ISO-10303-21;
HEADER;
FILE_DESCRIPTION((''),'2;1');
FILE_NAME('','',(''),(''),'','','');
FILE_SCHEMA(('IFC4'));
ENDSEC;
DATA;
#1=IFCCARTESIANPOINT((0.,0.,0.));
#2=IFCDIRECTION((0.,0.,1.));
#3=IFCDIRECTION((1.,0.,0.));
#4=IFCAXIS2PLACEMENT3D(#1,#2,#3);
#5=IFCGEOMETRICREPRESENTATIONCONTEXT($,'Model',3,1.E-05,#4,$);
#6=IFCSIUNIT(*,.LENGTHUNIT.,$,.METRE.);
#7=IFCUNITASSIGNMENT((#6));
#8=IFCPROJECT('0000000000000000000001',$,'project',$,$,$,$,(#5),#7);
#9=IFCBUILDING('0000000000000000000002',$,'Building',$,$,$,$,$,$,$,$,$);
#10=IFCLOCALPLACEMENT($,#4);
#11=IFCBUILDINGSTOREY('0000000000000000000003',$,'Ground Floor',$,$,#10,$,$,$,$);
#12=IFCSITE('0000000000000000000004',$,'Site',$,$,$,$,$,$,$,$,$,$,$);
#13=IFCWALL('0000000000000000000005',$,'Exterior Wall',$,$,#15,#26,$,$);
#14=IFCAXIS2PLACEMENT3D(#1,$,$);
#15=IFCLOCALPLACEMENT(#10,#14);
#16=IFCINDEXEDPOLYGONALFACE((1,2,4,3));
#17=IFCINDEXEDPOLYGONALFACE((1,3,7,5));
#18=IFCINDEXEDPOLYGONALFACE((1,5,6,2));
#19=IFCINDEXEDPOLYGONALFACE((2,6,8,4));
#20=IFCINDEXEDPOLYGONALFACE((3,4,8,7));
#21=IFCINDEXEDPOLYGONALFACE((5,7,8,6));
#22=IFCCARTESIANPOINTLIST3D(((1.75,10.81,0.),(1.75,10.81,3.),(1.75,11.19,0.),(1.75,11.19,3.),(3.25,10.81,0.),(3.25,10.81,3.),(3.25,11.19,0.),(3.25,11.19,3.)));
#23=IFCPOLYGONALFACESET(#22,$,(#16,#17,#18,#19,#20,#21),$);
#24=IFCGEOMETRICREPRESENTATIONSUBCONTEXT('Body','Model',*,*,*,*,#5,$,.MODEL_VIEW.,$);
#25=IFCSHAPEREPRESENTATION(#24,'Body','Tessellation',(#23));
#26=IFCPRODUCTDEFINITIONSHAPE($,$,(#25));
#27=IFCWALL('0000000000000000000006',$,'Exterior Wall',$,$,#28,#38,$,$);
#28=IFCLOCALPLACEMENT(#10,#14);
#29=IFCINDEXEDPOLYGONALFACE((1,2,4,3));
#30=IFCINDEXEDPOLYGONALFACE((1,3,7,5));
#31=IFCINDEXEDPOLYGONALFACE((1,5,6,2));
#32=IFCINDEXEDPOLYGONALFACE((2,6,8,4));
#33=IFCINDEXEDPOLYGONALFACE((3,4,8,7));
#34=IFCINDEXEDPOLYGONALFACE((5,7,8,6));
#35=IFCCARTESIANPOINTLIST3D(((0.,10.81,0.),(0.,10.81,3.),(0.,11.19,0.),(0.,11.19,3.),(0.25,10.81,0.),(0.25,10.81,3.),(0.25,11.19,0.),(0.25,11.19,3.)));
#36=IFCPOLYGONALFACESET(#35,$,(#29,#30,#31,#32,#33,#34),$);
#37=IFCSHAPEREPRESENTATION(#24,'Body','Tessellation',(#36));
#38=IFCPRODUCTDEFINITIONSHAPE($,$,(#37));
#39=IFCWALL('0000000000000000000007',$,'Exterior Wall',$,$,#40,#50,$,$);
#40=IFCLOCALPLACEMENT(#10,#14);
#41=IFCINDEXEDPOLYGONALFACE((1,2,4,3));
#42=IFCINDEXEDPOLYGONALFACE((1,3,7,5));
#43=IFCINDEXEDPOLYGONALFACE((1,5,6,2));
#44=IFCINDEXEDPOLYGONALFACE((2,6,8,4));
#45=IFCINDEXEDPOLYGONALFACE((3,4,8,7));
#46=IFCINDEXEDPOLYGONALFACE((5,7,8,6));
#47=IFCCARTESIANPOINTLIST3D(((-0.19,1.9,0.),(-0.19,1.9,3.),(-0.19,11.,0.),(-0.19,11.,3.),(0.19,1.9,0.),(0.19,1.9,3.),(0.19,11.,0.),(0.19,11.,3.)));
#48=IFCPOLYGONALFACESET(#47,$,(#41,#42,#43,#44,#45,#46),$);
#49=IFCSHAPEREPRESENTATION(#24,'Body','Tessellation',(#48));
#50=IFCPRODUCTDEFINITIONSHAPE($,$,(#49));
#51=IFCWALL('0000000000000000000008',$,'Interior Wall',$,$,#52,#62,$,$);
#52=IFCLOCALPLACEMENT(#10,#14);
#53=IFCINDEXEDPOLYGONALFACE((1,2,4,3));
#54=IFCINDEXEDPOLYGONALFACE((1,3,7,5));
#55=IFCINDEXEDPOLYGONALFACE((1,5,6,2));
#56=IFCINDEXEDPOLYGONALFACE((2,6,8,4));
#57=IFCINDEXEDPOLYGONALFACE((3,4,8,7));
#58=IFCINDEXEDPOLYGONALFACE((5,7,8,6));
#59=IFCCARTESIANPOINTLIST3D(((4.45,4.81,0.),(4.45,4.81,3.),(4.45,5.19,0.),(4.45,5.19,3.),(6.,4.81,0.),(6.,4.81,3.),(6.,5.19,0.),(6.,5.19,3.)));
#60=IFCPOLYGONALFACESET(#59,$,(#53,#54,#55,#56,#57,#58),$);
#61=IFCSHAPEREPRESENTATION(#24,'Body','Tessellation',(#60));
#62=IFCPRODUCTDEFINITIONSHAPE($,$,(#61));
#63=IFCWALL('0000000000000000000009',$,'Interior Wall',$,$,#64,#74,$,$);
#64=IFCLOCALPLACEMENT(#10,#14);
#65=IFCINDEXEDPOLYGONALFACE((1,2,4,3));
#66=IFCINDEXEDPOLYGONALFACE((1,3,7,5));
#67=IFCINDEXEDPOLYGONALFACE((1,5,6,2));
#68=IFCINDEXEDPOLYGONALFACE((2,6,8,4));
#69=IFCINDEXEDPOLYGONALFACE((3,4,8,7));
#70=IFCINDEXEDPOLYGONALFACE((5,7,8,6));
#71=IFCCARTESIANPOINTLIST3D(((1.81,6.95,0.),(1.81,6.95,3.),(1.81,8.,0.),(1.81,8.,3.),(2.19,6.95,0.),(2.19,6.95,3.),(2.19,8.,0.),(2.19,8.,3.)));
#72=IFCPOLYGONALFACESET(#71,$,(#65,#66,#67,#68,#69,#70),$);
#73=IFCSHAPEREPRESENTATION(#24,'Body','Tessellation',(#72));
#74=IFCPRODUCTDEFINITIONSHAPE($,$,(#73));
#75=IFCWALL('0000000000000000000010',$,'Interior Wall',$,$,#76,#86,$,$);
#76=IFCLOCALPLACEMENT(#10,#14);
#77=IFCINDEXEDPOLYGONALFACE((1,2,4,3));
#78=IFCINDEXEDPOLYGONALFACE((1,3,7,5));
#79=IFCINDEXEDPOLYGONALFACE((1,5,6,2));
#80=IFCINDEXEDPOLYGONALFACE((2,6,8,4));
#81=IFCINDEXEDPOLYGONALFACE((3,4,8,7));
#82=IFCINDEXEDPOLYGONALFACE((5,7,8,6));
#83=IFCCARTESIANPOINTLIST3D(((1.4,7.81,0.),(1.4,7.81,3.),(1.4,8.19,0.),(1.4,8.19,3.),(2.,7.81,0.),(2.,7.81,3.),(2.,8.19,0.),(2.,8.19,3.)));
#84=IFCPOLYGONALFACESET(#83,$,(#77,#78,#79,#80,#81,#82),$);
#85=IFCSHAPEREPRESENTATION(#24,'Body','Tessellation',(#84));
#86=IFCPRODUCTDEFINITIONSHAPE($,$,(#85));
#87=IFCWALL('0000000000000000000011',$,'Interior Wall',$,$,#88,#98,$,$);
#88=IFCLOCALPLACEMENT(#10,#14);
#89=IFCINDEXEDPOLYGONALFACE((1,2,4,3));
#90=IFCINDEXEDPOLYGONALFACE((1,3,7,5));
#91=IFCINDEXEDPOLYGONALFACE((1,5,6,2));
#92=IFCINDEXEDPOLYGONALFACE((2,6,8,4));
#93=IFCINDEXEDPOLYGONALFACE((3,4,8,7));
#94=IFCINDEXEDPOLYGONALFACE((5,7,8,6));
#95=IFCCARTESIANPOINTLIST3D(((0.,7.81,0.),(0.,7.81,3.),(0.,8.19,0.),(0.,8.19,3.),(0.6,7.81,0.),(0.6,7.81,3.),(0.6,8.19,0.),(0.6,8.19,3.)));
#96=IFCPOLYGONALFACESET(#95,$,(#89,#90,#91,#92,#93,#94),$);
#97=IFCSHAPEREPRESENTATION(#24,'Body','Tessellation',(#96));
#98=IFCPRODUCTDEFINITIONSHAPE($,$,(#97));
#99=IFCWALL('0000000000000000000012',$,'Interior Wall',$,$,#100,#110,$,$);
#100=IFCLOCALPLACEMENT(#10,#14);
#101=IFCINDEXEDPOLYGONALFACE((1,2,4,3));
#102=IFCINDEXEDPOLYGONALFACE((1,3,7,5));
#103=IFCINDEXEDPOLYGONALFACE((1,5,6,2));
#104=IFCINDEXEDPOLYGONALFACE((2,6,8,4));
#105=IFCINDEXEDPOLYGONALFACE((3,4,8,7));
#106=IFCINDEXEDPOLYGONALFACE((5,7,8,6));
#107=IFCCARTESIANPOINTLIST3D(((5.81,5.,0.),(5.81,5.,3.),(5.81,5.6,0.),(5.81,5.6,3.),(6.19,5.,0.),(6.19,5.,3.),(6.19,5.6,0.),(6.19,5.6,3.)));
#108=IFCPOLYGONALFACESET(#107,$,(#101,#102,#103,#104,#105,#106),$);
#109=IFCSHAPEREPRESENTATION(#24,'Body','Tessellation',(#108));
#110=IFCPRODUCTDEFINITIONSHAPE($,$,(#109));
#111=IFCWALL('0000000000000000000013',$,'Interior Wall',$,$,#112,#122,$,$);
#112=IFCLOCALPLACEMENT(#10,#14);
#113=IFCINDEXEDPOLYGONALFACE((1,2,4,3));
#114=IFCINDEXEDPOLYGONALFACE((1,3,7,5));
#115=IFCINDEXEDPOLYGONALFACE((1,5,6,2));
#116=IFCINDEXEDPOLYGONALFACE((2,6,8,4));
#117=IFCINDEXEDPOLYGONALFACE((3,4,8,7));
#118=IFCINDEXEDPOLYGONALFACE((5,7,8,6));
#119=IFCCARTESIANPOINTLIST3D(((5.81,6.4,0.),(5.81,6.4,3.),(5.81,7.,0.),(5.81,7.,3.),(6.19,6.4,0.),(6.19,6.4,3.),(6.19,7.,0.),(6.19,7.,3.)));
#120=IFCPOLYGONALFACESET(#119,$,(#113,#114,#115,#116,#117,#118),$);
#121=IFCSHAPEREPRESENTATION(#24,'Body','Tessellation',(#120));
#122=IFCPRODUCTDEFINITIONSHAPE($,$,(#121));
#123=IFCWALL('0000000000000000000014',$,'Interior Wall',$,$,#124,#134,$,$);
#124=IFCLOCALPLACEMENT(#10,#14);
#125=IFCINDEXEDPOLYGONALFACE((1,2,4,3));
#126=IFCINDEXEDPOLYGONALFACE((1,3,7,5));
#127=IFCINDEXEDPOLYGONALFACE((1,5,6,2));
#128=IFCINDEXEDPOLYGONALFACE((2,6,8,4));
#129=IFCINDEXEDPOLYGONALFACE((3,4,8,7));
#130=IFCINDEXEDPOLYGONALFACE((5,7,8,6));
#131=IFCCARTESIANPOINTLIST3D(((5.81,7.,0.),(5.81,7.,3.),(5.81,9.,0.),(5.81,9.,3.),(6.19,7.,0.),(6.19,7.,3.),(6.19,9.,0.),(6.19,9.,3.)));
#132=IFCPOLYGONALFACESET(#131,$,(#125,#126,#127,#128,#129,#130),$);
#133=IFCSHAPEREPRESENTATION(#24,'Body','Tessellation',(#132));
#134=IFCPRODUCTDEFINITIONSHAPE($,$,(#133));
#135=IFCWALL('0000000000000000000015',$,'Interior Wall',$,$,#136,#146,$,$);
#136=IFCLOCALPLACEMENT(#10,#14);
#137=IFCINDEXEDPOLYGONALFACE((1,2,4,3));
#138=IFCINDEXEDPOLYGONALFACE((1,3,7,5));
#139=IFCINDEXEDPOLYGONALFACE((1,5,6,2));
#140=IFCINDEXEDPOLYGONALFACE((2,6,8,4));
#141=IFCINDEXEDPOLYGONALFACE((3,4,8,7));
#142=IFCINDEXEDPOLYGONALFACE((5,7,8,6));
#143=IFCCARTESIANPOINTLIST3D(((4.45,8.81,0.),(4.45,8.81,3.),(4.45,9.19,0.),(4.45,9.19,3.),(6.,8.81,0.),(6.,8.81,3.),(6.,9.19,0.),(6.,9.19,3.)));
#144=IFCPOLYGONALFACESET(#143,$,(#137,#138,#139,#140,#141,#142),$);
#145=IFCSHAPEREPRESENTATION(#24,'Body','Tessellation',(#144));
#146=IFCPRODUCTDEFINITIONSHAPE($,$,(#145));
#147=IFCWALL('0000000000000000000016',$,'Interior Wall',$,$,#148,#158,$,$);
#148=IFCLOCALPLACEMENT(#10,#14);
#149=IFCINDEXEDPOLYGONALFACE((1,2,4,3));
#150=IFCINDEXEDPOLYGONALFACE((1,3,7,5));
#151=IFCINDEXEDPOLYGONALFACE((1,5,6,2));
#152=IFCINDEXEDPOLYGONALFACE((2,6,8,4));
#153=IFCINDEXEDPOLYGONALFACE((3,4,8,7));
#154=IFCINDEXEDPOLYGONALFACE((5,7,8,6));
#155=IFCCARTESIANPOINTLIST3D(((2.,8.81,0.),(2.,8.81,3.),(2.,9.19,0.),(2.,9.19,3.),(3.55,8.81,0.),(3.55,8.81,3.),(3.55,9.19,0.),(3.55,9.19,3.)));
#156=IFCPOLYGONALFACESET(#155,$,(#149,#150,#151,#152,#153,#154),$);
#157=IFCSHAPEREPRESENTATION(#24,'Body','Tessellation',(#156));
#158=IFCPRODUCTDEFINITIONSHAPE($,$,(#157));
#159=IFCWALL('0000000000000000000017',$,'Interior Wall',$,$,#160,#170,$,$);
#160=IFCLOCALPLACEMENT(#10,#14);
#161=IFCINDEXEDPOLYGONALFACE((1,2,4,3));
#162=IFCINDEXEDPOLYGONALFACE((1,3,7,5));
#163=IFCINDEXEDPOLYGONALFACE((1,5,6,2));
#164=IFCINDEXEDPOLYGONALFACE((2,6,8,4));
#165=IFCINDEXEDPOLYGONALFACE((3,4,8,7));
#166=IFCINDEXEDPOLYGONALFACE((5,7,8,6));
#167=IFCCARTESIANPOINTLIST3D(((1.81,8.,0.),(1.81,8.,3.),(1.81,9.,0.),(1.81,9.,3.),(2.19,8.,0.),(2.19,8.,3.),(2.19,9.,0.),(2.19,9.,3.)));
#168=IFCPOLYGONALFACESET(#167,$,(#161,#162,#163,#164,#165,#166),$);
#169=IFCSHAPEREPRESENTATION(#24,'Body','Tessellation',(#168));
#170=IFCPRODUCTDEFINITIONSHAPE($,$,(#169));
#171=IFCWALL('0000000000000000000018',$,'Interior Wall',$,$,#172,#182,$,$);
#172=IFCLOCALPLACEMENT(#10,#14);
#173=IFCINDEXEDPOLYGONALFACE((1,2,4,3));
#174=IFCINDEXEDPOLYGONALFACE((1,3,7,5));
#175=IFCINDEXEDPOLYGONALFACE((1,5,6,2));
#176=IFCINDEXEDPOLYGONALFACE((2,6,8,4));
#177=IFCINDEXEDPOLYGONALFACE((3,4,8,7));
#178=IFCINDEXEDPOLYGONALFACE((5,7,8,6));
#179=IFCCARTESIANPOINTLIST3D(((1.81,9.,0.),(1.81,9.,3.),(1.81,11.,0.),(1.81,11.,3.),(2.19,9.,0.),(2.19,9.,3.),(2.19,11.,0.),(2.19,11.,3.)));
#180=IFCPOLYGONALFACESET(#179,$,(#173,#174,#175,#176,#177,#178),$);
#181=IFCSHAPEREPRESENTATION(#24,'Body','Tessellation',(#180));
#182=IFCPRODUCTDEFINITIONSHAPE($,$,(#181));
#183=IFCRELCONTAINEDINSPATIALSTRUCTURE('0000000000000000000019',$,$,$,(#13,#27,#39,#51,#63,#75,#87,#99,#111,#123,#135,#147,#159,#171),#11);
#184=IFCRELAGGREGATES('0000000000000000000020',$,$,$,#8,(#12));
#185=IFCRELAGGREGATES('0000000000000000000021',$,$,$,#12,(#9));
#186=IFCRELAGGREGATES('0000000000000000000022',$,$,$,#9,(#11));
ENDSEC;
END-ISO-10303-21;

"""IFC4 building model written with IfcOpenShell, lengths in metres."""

from ifc_helpers import new_model, si_unit, frame, origin_with_axes, place, context, subcontext, project, spatial, indexed_curve, outline, extrude, element, save


model = new_model("IFC4")

# Units and contexts
model_context = context("Model", 3, precision=1e-05, world=origin_with_axes())
body_context = subcontext(model_context, "Body", "Model", "MODEL_VIEW")
ifc_project = project(units=[si_unit("LENGTHUNIT", "METRE")], contexts=[model_context])

# Site, building, storey
site = spatial("IfcSite", under=ifc_project, Name="Site")
building = spatial("IfcBuilding", under=site, Name="Building")
storey_placement = place(None, origin_with_axes())
storey = spatial("IfcBuildingStorey", under=building, at=storey_placement, Name="Ground Floor")

# Walls
wall_1_placement = place(storey_placement, frame((3.25, 11.0, 0.0), z_axis=(0.0, 0.0, 1.0), x_axis=(-1.0, 0.0, 0.0)))
element("IfcWall", 1, at=wall_1_placement, inside=storey, Name="Exterior Wall", context=body_context, shape_type="SweptSolid", body=[
    extrude(outline(indexed_curve([(0.0, 0.0), (0.0, 0.38), (1.5, 0.38), (1.5, 0.0), (0.0, 0.0)], self_intersect=False)), frame((0.0, -0.19, 0.0), z_axis=(0.0, 0.0, 1.0), x_axis=(1.0, 0.0, 0.0)), (0.0, 0.0, 1.0), 3.0),
])
wall_2_placement = place(storey_placement, frame((0.25, 11.0, 0.0), z_axis=(0.0, 0.0, 1.0), x_axis=(-1.0, 0.0, 0.0)))
element("IfcWall", 2, at=wall_2_placement, inside=storey, Name="Exterior Wall", context=body_context, shape_type="SweptSolid", body=[
    extrude(outline(indexed_curve([(0.0, 0.0), (0.0, 0.38), (0.25, 0.38), (0.25, 0.0), (0.0, 0.0)], self_intersect=False)), frame((0.0, -0.19, 0.0), z_axis=(0.0, 0.0, 1.0), x_axis=(1.0, 0.0, 0.0)), (0.0, 0.0, 1.0), 3.0),
])
wall_3_placement = place(storey_placement, frame((0.0, 11.0, 0.0), z_axis=(0.0, 0.0, 1.0), x_axis=(0.0, -1.0, 0.0)))
element("IfcWall", 3, at=wall_3_placement, inside=storey, Name="Exterior Wall", context=body_context, shape_type="SweptSolid", body=[
    extrude(outline(indexed_curve([(0.0, 0.0), (0.0, 0.38), (9.1, 0.38), (9.1, 0.0), (0.0, 0.0)], self_intersect=False)), frame((0.0, -0.19, 0.0), z_axis=(0.0, 0.0, 1.0), x_axis=(1.0, 0.0, 0.0)), (0.0, 0.0, 1.0), 3.0),
])
wall_4_placement = place(storey_placement, frame((6.0, 5.0, 0.0), z_axis=(0.0, 0.0, 1.0), x_axis=(-1.0, 0.0, 0.0)))
element("IfcWall", 4, at=wall_4_placement, inside=storey, Name="Interior Wall", context=body_context, shape_type="SweptSolid", body=[
    extrude(outline(indexed_curve([(0.0, 0.0), (0.0, 0.38), (1.55, 0.38), (1.55, 0.0), (0.0, 0.0)], self_intersect=False)), frame((0.0, -0.19, 0.0), z_axis=(0.0, 0.0, 1.0), x_axis=(1.0, 0.0, 0.0)), (0.0, 0.0, 1.0), 3.0),
])
wall_5_placement = place(storey_placement, frame((2.0, 6.95, 0.0), z_axis=(0.0, 0.0, 1.0), x_axis=(0.0, 1.0, 0.0)))
element("IfcWall", 5, at=wall_5_placement, inside=storey, Name="Interior Wall", context=body_context, shape_type="SweptSolid", body=[
    extrude(outline(indexed_curve([(0.0, 0.0), (0.0, 0.38), (1.05, 0.38), (1.05, 0.0), (0.0, 0.0)], self_intersect=False)), frame((0.0, -0.19, 0.0), z_axis=(0.0, 0.0, 1.0), x_axis=(1.0, 0.0, 0.0)), (0.0, 0.0, 1.0), 3.0),
])
for number, where, z_axis, x_axis, name in (
    (6, (2.0, 8.0, 0.0), (0.0, 0.0, 1.0), (-1.0, 0.0, 0.0), "Interior Wall"),
    (7, (0.6, 8.0, 0.0), (0.0, 0.0, 1.0), (-1.0, 0.0, 0.0), "Interior Wall"),
):
    element("IfcWall", number, at=place(storey_placement, frame(where, z_axis=z_axis, x_axis=x_axis)), inside=storey, Name=name, context=body_context, shape_type="SweptSolid", body=[
        extrude(outline(indexed_curve([(0.0, 0.0), (0.0, 0.38), (0.6, 0.38), (0.6, 0.0), (0.0, 0.0)], self_intersect=False)), frame((0.0, -0.19, 0.0), z_axis=(0.0, 0.0, 1.0), x_axis=(1.0, 0.0, 0.0)), (0.0, 0.0, 1.0), 3.0),
    ])
for number, where, z_axis, x_axis, name in (
    (8, (6.0, 5.0, 0.0), (0.0, 0.0, 1.0), (0.0, 1.0, 0.0), "Interior Wall"),
    (9, (6.0, 6.4, 0.0), (0.0, 0.0, 1.0), (0.0, 1.0, 0.0), "Interior Wall"),
):
    element("IfcWall", number, at=place(storey_placement, frame(where, z_axis=z_axis, x_axis=x_axis)), inside=storey, Name=name, context=body_context, shape_type="SweptSolid", body=[
        extrude(outline(indexed_curve([(0.0, 0.0), (0.0, 0.38), (0.6, 0.38), (0.6, 0.0), (0.0, 0.0)], self_intersect=False)), frame((0.0, -0.19, 0.0), z_axis=(0.0, 0.0, 1.0), x_axis=(1.0, 0.0, 0.0)), (0.0, 0.0, 1.0), 3.0),
    ])
wall_6_placement = place(storey_placement, frame((6.0, 7.0, 0.0), z_axis=(0.0, 0.0, 1.0), x_axis=(0.0, 1.0, 0.0)))
element("IfcWall", 10, at=wall_6_placement, inside=storey, Name="Interior Wall", context=body_context, shape_type="SweptSolid", body=[
    extrude(outline(indexed_curve([(0.0, 0.0), (0.0, 0.38), (2.0, 0.38), (2.0, 0.0), (0.0, 0.0)], self_intersect=False)), frame((0.0, -0.19, 0.0), z_axis=(0.0, 0.0, 1.0), x_axis=(1.0, 0.0, 0.0)), (0.0, 0.0, 1.0), 3.0),
])
for number, where, z_axis, x_axis, name in (
    (11, (6.0, 9.0, 0.0), (0.0, 0.0, 1.0), (-1.0, 0.0, 0.0), "Interior Wall"),
    (12, (3.55, 9.0, 0.0), (0.0, 0.0, 1.0), (-1.0, 0.0, 0.0), "Interior Wall"),
):
    element("IfcWall", number, at=place(storey_placement, frame(where, z_axis=z_axis, x_axis=x_axis)), inside=storey, Name=name, context=body_context, shape_type="SweptSolid", body=[
        extrude(outline(indexed_curve([(0.0, 0.0), (0.0, 0.38), (1.55, 0.38), (1.55, 0.0), (0.0, 0.0)], self_intersect=False)), frame((0.0, -0.19, 0.0), z_axis=(0.0, 0.0, 1.0), x_axis=(1.0, 0.0, 0.0)), (0.0, 0.0, 1.0), 3.0),
    ])
wall_7_placement = place(storey_placement, frame((2.0, 9.0, 0.0), z_axis=(0.0, 0.0, 1.0), x_axis=(0.0, -1.0, 0.0)))
element("IfcWall", 13, at=wall_7_placement, inside=storey, Name="Interior Wall", context=body_context, shape_type="SweptSolid", body=[
    extrude(outline(indexed_curve([(0.0, 0.0), (0.0, 0.38), (1.0, 0.38), (1.0, 0.0), (0.0, 0.0)], self_intersect=False)), frame((0.0, -0.19, 0.0), z_axis=(0.0, 0.0, 1.0), x_axis=(1.0, 0.0, 0.0)), (0.0, 0.0, 1.0), 3.0),
])
wall_8_placement = place(storey_placement, frame((2.0, 11.0, 0.0), z_axis=(0.0, 0.0, 1.0), x_axis=(0.0, -1.0, 0.0)))
element("IfcWall", 14, at=wall_8_placement, inside=storey, Name="Interior Wall", context=body_context, shape_type="SweptSolid", body=[
    extrude(outline(indexed_curve([(0.0, 0.0), (0.0, 0.38), (2.0, 0.38), (2.0, 0.0), (0.0, 0.0)], self_intersect=False)), frame((0.0, -0.19, 0.0), z_axis=(0.0, 0.0, 1.0), x_axis=(1.0, 0.0, 0.0)), (0.0, 0.0, 1.0), 3.0),
])

save(model, "model.ifc")
